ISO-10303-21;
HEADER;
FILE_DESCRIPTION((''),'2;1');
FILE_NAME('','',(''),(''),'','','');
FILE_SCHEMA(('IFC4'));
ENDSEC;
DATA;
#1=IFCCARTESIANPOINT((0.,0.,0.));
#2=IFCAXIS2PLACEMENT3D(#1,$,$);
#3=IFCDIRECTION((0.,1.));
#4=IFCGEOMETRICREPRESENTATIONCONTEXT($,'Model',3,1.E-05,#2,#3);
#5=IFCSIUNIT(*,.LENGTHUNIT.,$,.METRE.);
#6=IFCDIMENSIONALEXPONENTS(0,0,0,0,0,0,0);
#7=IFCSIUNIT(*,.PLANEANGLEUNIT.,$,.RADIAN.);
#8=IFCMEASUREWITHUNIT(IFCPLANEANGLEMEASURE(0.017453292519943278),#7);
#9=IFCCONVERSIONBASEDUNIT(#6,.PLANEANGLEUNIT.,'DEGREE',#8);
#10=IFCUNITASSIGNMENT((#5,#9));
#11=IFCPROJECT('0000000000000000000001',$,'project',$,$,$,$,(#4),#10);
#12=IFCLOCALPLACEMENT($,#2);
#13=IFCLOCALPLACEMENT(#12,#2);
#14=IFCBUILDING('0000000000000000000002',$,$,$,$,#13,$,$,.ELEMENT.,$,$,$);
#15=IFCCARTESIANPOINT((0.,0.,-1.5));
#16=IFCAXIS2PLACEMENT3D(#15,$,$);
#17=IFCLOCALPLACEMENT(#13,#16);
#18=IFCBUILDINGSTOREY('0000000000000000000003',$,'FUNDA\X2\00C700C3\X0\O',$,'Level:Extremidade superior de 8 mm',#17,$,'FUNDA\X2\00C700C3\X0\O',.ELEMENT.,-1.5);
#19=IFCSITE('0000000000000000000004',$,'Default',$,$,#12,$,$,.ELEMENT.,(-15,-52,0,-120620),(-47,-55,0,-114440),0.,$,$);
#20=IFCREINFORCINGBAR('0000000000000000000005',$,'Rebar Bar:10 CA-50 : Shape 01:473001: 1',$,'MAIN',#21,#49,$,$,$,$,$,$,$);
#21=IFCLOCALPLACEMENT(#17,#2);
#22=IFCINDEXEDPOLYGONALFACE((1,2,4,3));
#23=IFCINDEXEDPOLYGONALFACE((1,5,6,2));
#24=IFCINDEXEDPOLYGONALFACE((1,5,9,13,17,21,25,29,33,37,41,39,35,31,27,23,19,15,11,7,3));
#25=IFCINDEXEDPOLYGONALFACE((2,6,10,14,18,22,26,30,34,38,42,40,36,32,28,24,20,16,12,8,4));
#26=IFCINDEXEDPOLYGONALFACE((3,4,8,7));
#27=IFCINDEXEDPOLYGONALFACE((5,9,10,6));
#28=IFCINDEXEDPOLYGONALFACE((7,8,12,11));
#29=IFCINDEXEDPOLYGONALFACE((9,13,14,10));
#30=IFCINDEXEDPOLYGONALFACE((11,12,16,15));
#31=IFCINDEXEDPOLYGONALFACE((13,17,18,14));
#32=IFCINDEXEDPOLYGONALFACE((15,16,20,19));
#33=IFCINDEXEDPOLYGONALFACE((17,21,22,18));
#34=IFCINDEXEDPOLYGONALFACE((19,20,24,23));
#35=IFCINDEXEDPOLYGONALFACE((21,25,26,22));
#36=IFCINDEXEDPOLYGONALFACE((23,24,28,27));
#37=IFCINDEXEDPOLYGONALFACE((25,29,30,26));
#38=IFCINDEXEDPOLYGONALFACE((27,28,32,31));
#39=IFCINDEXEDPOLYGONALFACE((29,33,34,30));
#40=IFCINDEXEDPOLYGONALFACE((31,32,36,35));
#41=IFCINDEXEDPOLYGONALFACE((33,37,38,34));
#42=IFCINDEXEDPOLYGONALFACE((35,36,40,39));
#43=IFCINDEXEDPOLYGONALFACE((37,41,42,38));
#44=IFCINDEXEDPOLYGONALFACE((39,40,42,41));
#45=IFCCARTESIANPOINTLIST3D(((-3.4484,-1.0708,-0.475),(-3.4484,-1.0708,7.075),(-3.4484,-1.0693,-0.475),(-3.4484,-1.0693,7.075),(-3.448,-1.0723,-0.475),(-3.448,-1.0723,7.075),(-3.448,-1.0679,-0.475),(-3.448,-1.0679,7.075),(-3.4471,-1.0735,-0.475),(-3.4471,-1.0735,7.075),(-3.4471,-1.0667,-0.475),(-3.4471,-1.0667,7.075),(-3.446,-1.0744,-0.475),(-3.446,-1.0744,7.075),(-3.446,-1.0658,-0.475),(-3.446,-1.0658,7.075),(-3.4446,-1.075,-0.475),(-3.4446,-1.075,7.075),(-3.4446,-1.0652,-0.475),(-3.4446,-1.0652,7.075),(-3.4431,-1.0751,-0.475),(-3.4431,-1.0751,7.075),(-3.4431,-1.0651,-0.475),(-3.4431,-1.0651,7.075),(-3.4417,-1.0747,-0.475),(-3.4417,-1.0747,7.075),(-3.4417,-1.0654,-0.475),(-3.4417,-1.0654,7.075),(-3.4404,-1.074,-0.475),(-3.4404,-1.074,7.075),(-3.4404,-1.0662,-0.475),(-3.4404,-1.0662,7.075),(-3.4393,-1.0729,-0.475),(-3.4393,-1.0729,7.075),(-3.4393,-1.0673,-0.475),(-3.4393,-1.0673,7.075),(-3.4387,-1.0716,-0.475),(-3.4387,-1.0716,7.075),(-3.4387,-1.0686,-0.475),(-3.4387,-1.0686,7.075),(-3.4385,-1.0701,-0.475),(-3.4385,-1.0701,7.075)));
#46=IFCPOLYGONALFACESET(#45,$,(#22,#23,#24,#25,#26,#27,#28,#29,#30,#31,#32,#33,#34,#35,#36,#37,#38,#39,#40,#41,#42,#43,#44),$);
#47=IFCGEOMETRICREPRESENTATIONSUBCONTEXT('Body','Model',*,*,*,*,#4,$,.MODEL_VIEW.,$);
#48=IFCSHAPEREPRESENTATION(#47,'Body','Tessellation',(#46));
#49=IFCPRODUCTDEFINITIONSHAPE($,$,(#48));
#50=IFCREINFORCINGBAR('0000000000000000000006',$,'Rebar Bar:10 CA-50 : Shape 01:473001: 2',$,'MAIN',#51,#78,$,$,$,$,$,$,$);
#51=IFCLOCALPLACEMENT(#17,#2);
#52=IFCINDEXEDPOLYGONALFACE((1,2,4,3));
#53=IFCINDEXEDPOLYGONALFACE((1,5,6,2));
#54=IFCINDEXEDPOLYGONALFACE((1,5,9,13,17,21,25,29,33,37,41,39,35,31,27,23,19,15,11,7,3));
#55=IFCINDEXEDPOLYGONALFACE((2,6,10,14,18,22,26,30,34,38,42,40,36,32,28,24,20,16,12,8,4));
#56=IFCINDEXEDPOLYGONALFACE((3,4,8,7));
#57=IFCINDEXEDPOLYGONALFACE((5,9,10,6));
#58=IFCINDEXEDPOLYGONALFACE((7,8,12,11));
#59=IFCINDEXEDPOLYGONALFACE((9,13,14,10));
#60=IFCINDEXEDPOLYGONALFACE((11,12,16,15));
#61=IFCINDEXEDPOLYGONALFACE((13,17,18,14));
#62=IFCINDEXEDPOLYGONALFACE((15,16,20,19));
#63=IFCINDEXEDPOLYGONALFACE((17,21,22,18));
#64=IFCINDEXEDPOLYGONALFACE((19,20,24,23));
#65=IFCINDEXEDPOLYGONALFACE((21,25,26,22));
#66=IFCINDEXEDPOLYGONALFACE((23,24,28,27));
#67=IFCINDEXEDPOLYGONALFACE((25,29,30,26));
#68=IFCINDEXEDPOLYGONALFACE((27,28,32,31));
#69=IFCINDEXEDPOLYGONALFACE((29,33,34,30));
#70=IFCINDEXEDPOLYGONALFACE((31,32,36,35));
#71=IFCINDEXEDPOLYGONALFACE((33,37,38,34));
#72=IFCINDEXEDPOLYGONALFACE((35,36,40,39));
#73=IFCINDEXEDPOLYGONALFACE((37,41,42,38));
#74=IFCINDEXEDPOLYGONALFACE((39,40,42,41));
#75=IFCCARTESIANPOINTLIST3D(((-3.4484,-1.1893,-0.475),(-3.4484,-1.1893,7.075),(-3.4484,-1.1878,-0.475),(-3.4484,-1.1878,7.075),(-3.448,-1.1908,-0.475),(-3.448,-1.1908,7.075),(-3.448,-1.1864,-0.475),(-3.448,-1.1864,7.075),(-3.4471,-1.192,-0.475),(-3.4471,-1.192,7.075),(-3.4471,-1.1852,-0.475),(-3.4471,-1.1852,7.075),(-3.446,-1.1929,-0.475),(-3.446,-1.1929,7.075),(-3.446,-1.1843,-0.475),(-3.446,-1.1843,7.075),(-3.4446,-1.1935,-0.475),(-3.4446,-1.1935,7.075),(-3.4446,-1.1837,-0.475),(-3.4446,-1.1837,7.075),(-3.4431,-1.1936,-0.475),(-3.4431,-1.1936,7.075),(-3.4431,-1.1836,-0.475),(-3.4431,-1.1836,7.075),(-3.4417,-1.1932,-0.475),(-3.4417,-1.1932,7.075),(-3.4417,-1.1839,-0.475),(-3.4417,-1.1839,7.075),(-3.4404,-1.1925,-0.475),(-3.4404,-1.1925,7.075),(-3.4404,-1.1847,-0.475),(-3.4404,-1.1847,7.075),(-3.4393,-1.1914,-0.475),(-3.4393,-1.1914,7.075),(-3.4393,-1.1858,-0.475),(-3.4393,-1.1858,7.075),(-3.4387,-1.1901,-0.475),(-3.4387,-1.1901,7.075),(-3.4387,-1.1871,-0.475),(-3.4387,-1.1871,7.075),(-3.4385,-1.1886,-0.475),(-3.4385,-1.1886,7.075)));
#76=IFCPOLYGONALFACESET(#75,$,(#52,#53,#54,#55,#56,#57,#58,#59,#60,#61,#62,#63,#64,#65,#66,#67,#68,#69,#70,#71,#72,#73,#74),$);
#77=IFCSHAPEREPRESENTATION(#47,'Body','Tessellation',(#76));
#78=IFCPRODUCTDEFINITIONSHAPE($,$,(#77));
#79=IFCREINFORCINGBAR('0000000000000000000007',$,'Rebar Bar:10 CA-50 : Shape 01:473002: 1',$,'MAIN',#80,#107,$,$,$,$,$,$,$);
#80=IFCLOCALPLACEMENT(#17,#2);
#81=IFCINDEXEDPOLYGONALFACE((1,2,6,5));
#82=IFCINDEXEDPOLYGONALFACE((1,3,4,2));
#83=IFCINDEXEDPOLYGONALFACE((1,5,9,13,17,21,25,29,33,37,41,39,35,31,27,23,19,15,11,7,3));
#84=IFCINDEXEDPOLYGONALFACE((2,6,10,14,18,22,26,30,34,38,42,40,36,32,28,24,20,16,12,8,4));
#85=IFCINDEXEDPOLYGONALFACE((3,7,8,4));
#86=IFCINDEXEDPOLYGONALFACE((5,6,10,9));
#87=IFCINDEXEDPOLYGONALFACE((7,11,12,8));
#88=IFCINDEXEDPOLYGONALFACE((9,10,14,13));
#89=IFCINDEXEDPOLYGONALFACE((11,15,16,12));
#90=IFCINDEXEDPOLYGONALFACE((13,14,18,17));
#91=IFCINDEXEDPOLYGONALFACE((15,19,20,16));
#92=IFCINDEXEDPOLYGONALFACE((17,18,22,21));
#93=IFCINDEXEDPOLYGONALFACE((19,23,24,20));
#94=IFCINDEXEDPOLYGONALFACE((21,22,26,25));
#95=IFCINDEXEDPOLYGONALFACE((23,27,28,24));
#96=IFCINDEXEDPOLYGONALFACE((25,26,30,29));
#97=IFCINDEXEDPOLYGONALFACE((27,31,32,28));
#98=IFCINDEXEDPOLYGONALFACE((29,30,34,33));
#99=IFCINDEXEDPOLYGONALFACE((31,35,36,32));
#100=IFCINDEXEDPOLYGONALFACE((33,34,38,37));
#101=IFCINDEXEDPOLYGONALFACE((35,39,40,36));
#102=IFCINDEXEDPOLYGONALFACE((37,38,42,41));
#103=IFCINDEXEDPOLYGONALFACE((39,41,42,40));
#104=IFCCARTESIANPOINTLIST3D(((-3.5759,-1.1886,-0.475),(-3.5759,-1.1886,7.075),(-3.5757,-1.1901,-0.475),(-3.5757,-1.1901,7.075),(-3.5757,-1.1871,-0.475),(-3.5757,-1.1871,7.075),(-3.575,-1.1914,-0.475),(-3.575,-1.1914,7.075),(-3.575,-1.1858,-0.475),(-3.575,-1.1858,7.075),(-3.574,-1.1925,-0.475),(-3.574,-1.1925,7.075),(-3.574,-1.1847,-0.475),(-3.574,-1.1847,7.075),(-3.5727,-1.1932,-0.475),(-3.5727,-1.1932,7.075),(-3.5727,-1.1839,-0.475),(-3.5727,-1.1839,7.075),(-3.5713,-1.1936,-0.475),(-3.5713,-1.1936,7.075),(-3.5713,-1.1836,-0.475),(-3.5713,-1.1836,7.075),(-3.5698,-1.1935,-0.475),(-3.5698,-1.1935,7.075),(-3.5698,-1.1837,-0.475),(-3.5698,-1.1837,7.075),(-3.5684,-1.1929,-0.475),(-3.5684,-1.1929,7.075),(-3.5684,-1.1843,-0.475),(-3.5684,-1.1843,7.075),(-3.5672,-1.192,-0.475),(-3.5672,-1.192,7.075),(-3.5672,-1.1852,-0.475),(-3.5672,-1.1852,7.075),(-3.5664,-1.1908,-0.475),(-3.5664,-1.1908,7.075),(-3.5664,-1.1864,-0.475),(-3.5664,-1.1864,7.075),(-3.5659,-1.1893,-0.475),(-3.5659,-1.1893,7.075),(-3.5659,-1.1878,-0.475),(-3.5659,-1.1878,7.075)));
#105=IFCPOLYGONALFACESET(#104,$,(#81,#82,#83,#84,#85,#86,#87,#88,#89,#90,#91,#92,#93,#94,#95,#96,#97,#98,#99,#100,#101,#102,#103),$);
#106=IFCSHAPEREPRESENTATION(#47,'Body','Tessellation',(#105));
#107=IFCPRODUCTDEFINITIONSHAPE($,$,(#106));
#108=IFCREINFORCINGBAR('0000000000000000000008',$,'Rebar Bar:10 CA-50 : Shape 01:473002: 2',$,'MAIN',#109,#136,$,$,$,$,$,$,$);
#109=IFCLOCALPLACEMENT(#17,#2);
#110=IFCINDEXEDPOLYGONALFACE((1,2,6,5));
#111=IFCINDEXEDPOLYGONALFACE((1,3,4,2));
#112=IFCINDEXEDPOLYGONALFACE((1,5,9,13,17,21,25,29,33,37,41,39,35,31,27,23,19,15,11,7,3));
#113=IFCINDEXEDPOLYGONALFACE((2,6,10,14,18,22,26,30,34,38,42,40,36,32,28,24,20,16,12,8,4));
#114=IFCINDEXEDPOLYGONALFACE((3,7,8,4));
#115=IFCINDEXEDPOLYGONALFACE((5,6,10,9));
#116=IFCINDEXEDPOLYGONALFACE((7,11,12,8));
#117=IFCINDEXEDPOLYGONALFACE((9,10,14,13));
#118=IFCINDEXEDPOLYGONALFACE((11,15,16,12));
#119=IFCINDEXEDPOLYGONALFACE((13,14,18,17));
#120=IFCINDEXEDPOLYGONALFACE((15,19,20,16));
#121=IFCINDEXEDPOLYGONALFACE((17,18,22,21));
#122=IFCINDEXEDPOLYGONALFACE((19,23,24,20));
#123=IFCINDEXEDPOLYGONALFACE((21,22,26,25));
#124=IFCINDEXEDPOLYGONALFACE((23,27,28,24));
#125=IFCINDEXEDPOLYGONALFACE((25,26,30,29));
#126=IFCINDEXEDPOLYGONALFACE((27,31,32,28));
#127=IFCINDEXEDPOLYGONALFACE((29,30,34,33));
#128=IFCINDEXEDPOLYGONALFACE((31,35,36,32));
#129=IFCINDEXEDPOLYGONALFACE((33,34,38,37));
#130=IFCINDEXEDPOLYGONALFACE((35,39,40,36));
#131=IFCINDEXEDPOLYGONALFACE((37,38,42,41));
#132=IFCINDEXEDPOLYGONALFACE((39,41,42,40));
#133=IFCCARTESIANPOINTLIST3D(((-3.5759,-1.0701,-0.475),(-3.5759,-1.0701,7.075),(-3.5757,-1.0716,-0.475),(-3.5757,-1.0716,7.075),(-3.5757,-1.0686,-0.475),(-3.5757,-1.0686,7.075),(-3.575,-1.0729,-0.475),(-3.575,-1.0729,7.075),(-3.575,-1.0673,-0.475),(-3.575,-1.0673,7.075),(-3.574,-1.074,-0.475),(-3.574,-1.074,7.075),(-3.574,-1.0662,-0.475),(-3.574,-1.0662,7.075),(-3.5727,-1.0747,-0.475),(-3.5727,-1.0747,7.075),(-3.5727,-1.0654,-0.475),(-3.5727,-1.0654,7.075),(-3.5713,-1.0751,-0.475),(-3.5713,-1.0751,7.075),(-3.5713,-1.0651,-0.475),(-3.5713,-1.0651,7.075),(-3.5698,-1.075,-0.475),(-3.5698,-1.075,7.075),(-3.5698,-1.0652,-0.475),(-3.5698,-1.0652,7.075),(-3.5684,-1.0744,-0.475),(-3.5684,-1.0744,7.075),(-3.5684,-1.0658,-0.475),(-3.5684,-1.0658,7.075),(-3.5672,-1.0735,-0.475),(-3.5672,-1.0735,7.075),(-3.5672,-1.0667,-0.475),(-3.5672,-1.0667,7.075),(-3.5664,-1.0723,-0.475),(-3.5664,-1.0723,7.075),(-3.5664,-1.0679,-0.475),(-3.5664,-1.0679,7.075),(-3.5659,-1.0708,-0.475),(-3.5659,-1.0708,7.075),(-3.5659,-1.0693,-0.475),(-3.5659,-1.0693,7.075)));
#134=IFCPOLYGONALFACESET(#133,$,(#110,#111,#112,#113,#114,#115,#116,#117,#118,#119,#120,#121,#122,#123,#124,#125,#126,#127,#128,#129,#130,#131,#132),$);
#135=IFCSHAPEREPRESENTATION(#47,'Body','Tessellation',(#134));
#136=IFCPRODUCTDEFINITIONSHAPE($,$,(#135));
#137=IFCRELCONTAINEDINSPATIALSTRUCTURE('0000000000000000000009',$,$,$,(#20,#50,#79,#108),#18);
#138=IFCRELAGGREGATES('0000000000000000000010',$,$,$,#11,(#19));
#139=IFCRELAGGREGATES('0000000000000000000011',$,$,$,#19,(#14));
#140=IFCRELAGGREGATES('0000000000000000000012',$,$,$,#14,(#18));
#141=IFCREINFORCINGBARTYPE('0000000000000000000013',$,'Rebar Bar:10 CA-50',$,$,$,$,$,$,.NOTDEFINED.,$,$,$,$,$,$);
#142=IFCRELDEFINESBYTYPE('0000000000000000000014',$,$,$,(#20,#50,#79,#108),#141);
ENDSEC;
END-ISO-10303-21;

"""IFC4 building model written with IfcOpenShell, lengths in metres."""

from ifc_helpers import new_model, entity, si_unit, converted_unit, direction, frame, origin, place, context, subcontext, project, spatial, type_object, element, save


model = new_model("IFC4")

# Units and contexts
model_context = context("Model", 3, precision=1e-05, world=origin(), true_north=direction((0.0, 1.0)))
body_context = subcontext(model_context, "Body", "Model", "MODEL_VIEW")
ifc_project = project(units=[si_unit("LENGTHUNIT", "METRE"), converted_unit("PLANEANGLEUNIT", "DEGREE", entity("IfcPlaneAngleMeasure", 0.017453292519943278), si_unit("PLANEANGLEUNIT", "RADIAN"), dimensions=[0, 0, 0, 0, 0, 0, 0])], contexts=[model_context])

# Site, building, storey
site_placement = place(None, origin())
site = spatial("IfcSite", under=ifc_project, at=site_placement, Name="Default", CompositionType="ELEMENT", RefLatitude=(-15, -52, 0, -120620), RefLongitude=(-47, -55, 0, -114440), RefElevation=0.0)
building_placement = place(site_placement, origin())
building = spatial("IfcBuilding", under=site, at=building_placement, CompositionType="ELEMENT")
storey_placement = place(building_placement, frame((0.0, 0.0, -1.5)))
storey = spatial("IfcBuildingStorey", under=building, at=storey_placement, Name="FUNDAÇÃO", ObjectType="Level:Extremidade superior de 8 mm", LongName="FUNDAÇÃO", CompositionType="ELEMENT", Elevation=-1.5)

# Reinforcing bars
reinforcing_bar_type_1 = type_object("IfcReinforcingBarType", Name="Rebar Bar:10 CA-50", PredefinedType="NOTDEFINED")
reinforcing_bar_1_placement = place(storey_placement, origin())
element("IfcReinforcingBar", 1, at=reinforcing_bar_1_placement, inside=storey, type_object=reinforcing_bar_type_1, Name="Rebar Bar:10 CA-50 : Shape 01:473001: 1", ObjectType="MAIN", context=body_context, shape_type="AdvancedSweptSolid", body=[
    entity("IfcSweptDiskSolid", entity("IfcIndexedPolyCurve", entity("IfcCartesianPointList3D", [[-3.4435, -1.0701, -0.475], [-3.4435, -1.0701, 7.075]]), None, False), 0.005, None, 0.0, 1.0),
])
reinforcing_bar_2_placement = place(storey_placement, origin())
element("IfcReinforcingBar", 2, at=reinforcing_bar_2_placement, inside=storey, type_object=reinforcing_bar_type_1, Name="Rebar Bar:10 CA-50 : Shape 01:473001: 2", ObjectType="MAIN", context=body_context, shape_type="AdvancedSweptSolid", body=[
    entity("IfcSweptDiskSolid", entity("IfcIndexedPolyCurve", entity("IfcCartesianPointList3D", [[-3.4435, -1.1886, -0.475], [-3.4435, -1.1886, 7.075]]), None, False), 0.005, None, 0.0, 1.0),
])
reinforcing_bar_3_placement = place(storey_placement, origin())
element("IfcReinforcingBar", 3, at=reinforcing_bar_3_placement, inside=storey, type_object=reinforcing_bar_type_1, Name="Rebar Bar:10 CA-50 : Shape 01:473002: 1", ObjectType="MAIN", context=body_context, shape_type="AdvancedSweptSolid", body=[
    entity("IfcSweptDiskSolid", entity("IfcIndexedPolyCurve", entity("IfcCartesianPointList3D", [[-3.5709, -1.1886, 7.075], [-3.5709, -1.1886, -0.475]]), None, False), 0.005, None, 0.0, 1.0),
])
reinforcing_bar_4_placement = place(storey_placement, origin())
element("IfcReinforcingBar", 4, at=reinforcing_bar_4_placement, inside=storey, type_object=reinforcing_bar_type_1, Name="Rebar Bar:10 CA-50 : Shape 01:473002: 2", ObjectType="MAIN", context=body_context, shape_type="AdvancedSweptSolid", body=[
    entity("IfcSweptDiskSolid", entity("IfcIndexedPolyCurve", entity("IfcCartesianPointList3D", [[-3.5709, -1.0701, 7.075], [-3.5709, -1.0701, -0.475]]), None, False), 0.005, None, 0.0, 1.0),
])

save(model, "model.ifc")
